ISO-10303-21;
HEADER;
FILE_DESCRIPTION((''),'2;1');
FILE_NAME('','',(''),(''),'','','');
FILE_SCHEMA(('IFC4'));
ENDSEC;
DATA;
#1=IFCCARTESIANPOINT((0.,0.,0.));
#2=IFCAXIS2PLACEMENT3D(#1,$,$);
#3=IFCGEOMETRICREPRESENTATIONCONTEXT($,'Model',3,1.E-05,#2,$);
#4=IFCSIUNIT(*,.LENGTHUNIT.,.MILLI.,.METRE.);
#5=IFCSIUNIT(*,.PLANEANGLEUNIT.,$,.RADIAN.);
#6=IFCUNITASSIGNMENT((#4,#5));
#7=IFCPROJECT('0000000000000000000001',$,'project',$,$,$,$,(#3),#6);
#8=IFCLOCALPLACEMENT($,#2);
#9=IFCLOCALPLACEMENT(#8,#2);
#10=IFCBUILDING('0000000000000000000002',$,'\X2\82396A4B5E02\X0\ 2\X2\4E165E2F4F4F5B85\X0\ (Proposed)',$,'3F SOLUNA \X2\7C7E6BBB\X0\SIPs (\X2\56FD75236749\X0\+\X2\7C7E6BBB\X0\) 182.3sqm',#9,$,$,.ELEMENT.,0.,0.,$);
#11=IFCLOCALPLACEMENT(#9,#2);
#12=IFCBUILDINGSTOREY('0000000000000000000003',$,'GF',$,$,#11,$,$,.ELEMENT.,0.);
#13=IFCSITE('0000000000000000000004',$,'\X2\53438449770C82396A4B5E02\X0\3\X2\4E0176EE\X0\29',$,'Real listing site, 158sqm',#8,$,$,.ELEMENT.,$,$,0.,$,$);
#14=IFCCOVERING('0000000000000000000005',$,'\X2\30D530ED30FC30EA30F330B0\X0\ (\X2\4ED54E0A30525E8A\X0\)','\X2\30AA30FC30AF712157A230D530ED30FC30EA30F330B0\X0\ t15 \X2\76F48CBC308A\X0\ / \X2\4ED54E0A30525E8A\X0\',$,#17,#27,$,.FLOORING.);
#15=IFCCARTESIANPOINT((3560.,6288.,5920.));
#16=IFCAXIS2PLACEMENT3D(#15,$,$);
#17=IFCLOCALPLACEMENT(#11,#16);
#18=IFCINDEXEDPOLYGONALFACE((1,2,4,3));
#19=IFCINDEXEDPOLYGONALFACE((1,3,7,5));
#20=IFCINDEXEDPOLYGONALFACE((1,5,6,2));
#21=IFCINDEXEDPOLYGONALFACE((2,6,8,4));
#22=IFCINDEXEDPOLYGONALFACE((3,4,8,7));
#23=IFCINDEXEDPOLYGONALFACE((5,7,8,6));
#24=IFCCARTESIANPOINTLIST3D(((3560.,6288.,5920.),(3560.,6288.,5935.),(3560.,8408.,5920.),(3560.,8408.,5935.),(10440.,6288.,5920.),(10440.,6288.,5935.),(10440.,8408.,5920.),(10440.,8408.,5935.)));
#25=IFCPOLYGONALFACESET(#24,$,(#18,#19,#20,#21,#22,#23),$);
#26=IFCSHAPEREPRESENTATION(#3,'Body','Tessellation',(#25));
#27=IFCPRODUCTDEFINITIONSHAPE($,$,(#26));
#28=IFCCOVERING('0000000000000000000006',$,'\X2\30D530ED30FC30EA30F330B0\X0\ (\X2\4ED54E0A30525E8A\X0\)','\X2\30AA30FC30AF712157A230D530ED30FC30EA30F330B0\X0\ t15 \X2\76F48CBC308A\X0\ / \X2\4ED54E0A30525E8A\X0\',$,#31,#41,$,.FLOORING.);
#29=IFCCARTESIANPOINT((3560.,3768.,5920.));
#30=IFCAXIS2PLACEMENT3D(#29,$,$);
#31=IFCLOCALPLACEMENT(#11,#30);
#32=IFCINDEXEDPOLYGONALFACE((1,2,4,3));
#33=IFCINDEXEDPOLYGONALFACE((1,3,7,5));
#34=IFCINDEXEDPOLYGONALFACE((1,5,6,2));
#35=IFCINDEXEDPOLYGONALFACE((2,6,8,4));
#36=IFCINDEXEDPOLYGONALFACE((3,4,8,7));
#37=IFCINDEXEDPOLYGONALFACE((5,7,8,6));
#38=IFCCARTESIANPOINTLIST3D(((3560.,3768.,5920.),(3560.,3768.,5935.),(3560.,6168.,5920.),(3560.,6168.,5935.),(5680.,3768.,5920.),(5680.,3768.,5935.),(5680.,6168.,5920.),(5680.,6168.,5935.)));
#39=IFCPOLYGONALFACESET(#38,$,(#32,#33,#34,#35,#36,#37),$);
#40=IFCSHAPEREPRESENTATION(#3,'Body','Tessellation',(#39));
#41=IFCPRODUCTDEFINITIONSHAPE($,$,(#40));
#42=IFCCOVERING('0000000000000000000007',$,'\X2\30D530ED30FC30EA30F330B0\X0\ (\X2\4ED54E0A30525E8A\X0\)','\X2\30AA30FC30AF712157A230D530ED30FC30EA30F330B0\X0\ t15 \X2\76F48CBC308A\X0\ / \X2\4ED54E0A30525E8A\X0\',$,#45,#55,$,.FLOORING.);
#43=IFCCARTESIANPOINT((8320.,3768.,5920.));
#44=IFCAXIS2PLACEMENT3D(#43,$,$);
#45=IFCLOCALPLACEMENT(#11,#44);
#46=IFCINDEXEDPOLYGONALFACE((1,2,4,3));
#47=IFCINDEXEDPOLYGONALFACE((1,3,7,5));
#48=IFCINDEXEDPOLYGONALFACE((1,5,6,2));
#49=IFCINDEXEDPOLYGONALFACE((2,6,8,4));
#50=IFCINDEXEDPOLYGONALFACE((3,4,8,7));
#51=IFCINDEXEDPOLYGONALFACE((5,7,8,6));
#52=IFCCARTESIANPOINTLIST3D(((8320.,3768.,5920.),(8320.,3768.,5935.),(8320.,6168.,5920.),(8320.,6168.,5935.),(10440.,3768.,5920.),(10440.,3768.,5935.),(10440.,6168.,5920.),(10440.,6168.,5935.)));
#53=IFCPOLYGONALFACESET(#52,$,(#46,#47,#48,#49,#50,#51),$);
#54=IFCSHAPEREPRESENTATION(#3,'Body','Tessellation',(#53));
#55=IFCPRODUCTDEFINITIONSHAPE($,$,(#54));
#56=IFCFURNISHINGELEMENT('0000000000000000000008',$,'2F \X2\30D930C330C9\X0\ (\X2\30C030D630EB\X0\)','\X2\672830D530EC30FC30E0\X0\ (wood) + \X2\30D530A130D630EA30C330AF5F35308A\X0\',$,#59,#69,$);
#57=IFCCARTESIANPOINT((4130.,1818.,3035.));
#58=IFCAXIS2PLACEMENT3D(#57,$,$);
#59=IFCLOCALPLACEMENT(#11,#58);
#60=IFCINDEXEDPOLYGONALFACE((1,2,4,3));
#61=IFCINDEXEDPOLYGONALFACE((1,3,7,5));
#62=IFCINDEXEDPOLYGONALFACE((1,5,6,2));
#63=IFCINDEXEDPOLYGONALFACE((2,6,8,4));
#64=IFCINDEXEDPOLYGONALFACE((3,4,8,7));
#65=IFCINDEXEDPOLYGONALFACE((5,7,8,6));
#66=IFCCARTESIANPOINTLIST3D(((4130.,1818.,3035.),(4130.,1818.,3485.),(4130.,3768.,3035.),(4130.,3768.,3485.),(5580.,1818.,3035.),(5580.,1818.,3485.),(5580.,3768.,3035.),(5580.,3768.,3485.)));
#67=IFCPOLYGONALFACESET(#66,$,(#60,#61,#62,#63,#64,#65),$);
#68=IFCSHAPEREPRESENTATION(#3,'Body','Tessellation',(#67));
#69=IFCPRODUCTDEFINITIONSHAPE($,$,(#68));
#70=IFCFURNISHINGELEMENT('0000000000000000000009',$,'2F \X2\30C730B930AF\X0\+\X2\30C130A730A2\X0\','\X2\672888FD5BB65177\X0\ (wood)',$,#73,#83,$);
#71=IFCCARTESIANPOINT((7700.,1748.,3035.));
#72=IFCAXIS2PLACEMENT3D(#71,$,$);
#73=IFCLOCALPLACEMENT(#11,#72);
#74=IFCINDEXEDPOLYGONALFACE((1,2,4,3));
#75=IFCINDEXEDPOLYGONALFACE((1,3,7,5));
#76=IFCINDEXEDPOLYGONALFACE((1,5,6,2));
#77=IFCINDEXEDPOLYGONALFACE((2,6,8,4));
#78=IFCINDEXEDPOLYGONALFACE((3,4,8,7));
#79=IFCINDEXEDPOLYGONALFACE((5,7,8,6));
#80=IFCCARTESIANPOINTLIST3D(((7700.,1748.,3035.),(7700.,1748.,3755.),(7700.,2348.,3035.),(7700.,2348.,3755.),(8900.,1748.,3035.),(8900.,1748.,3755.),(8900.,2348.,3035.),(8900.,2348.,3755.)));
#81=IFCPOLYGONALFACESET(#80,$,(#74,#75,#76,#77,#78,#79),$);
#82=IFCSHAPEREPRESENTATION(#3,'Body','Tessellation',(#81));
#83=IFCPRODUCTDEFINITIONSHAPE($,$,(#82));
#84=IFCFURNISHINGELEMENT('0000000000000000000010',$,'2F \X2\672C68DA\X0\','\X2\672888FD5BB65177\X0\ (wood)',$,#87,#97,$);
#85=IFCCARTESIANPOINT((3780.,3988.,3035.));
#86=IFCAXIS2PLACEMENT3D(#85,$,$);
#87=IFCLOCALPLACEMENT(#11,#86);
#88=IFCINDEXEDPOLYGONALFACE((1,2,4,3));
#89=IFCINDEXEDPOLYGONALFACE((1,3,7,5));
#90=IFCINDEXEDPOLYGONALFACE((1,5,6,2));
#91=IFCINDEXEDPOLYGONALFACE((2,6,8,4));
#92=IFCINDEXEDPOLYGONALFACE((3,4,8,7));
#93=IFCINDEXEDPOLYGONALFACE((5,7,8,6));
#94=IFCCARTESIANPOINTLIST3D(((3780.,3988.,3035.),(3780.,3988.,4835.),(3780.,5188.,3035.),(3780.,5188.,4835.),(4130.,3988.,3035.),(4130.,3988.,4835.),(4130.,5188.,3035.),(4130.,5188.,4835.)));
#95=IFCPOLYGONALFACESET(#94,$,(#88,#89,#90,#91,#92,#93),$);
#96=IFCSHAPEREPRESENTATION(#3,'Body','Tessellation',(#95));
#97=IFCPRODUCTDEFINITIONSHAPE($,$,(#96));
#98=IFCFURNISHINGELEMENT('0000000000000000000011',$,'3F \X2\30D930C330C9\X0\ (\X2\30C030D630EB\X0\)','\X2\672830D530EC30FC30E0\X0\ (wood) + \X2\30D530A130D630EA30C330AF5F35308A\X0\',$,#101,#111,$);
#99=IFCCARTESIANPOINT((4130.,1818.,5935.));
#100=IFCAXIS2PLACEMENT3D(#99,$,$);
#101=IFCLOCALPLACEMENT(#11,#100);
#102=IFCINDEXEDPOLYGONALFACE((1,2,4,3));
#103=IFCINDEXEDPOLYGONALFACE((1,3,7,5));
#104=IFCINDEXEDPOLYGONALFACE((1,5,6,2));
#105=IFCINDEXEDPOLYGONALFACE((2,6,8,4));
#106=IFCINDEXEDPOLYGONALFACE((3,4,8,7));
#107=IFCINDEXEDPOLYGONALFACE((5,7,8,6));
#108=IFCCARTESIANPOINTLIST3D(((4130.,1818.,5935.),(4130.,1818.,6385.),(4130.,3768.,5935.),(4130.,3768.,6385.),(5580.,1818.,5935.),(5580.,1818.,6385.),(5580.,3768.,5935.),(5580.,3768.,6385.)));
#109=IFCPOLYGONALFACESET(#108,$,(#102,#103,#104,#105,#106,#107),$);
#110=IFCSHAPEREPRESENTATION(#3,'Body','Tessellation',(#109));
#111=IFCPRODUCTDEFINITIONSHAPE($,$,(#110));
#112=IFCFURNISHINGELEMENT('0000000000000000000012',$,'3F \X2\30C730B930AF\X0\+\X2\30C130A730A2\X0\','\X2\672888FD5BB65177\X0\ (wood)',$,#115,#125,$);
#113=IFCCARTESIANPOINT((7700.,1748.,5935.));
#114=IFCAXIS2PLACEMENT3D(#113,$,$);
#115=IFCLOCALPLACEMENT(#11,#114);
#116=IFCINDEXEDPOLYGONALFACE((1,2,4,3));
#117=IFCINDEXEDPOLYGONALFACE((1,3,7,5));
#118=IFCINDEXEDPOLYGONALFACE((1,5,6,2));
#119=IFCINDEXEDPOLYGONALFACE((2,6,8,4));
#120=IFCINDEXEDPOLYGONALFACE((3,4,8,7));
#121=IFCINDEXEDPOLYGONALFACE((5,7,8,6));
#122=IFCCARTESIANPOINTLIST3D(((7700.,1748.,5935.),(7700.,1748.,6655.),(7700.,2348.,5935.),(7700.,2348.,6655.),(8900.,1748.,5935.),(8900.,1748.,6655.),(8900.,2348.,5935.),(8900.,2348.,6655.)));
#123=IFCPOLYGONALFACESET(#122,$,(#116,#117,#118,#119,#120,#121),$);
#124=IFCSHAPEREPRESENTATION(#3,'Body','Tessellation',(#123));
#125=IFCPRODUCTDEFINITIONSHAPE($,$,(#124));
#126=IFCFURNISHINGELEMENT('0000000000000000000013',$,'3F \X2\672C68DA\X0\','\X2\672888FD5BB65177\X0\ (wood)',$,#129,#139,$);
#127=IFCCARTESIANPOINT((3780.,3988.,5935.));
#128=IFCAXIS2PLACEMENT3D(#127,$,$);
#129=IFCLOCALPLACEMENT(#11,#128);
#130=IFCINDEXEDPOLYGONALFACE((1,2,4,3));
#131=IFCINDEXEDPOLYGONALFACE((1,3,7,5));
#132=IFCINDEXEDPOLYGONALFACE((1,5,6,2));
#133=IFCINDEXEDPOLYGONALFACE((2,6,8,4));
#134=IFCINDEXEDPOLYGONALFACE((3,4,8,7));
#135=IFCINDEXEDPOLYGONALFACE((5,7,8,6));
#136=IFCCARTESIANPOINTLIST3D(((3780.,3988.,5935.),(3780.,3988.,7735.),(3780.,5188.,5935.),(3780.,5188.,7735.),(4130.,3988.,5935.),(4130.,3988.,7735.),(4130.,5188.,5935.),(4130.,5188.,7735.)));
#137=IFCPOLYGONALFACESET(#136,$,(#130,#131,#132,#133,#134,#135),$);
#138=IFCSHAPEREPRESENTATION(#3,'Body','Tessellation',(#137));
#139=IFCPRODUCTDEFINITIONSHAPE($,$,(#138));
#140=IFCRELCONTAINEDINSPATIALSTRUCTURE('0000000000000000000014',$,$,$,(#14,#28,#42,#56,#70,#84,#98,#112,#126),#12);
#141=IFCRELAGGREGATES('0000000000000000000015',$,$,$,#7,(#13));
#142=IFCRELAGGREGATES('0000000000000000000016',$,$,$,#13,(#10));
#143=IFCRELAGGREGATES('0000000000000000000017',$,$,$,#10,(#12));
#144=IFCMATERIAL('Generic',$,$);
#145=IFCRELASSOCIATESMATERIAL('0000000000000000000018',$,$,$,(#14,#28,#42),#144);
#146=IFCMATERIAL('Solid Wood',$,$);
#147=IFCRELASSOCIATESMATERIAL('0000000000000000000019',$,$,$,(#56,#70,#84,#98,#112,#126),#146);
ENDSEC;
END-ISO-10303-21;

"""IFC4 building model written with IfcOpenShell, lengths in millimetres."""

from ifc_helpers import new_model, si_unit, frame, frame_2d, origin, place, context, project, spatial, rectangle, extrude, material, element, save


model = new_model("IFC4")

# Units and contexts
model_context = context("Model", 3, precision=1e-05, world=origin())
ifc_project = project(units=[si_unit("LENGTHUNIT", "METRE", prefix="MILLI"), si_unit("PLANEANGLEUNIT", "RADIAN")], contexts=[model_context])

# Site, building, storey
site_placement = place(None, origin())
site = spatial("IfcSite", under=ifc_project, at=site_placement, Name="千葉県船橋市3丁目29", ObjectType="Real listing site, 158sqm", CompositionType="ELEMENT", RefElevation=0.0)
building_placement = place(site_placement, origin())
building = spatial("IfcBuilding", under=site, at=building_placement, Name="船橋市 2世帯住宅 (Proposed)", ObjectType="3F SOLUNA 籾殻SIPs (国産杉+籾殻) 182.3sqm", CompositionType="ELEMENT", ElevationOfRefHeight=0.0, ElevationOfTerrain=0.0)
storey_placement = place(building_placement, origin())
storey = spatial("IfcBuildingStorey", under=building, at=storey_placement, Name="GF", CompositionType="ELEMENT", Elevation=0.0)

# Shared definitions
ifc_material_1 = material(Name="Solid Wood")

# Shared definitions
ifc_material_2 = material(Name="Generic")

# Coverings
covering_1_placement = place(storey_placement, frame((3560.0, 6288.0, 5920.0)))
element("IfcCovering", 1, at=covering_1_placement, inside=storey, material=ifc_material_2, Name="フローリング (仕上げ床)", Description="オーク無垢フローリング t15 直貼り / 仕上げ床", PredefinedType="FLOORING", context=model_context, shape_type="SweptSolid", body=[
    extrude(rectangle(XDim=6880.0, YDim=2120.0, at=frame_2d((3440.0, 1060.0))), frame((3560.0, 6288.0, 5920.0)), (0.0, 0.0, 1.0), 15.0),
])
covering_2_placement = place(storey_placement, frame((3560.0, 3768.0, 5920.0)))
element("IfcCovering", 2, at=covering_2_placement, inside=storey, material=ifc_material_2, Name="フローリング (仕上げ床)", Description="オーク無垢フローリング t15 直貼り / 仕上げ床", PredefinedType="FLOORING", context=model_context, shape_type="SweptSolid", body=[
    extrude(rectangle(XDim=2120.0, YDim=2400.0, at=frame_2d((1060.0, 1200.0))), frame((3560.0, 3768.0, 5920.0)), (0.0, 0.0, 1.0), 15.0),
])
covering_3_placement = place(storey_placement, frame((8320.0, 3768.0, 5920.0)))
element("IfcCovering", 3, at=covering_3_placement, inside=storey, material=ifc_material_2, Name="フローリング (仕上げ床)", Description="オーク無垢フローリング t15 直貼り / 仕上げ床", PredefinedType="FLOORING", context=model_context, shape_type="SweptSolid", body=[
    extrude(rectangle(XDim=2120.0, YDim=2400.0, at=frame_2d((1060.0, 1200.0))), frame((8320.0, 3768.0, 5920.0)), (0.0, 0.0, 1.0), 15.0),
])

# Furnishing elements
furnishing_1_placement = place(storey_placement, frame((4130.0, 1818.0, 3035.0)))
element("IfcFurnishingElement", 4, at=furnishing_1_placement, inside=storey, material=ifc_material_1, Name="2F ベッド (ダブル)", Description="木フレーム (wood) + ファブリック張り", context=model_context, shape_type="SweptSolid", body=[
    extrude(rectangle(XDim=1450.0, YDim=1950.0, at=frame_2d((725.0, 975.0))), frame((4130.0, 1818.0, 3035.0)), (0.0, 0.0, 1.0), 450.0),
])
furnishing_2_placement = place(storey_placement, frame((7700.0, 1748.0, 3035.0)))
element("IfcFurnishingElement", 5, at=furnishing_2_placement, inside=storey, material=ifc_material_1, Name="2F デスク+チェア", Description="木製家具 (wood)", context=model_context, shape_type="SweptSolid", body=[
    extrude(rectangle(XDim=1200.0, YDim=600.0, at=frame_2d((600.0, 300.0))), frame((7700.0, 1748.0, 3035.0)), (0.0, 0.0, 1.0), 720.0),
])
furnishing_3_placement = place(storey_placement, frame((3780.0, 3988.0, 3035.0)))
element("IfcFurnishingElement", 6, at=furnishing_3_placement, inside=storey, material=ifc_material_1, Name="2F 本棚", Description="木製家具 (wood)", context=model_context, shape_type="SweptSolid", body=[
    extrude(rectangle(XDim=350.0, YDim=1200.0, at=frame_2d((175.0, 600.0))), frame((3780.0, 3988.0, 3035.0)), (0.0, 0.0, 1.0), 1800.0),
])
furnishing_4_placement = place(storey_placement, frame((4130.0, 1818.0, 5935.0)))
element("IfcFurnishingElement", 7, at=furnishing_4_placement, inside=storey, material=ifc_material_1, Name="3F ベッド (ダブル)", Description="木フレーム (wood) + ファブリック張り", context=model_context, shape_type="SweptSolid", body=[
    extrude(rectangle(XDim=1450.0, YDim=1950.0, at=frame_2d((725.0, 975.0))), frame((4130.0, 1818.0, 5935.0)), (0.0, 0.0, 1.0), 450.0),
])
furnishing_5_placement = place(storey_placement, frame((7700.0, 1748.0, 5935.0)))
element("IfcFurnishingElement", 8, at=furnishing_5_placement, inside=storey, material=ifc_material_1, Name="3F デスク+チェア", Description="木製家具 (wood)", context=model_context, shape_type="SweptSolid", body=[
    extrude(rectangle(XDim=1200.0, YDim=600.0, at=frame_2d((600.0, 300.0))), frame((7700.0, 1748.0, 5935.0)), (0.0, 0.0, 1.0), 720.0),
])
furnishing_6_placement = place(storey_placement, frame((3780.0, 3988.0, 5935.0)))
element("IfcFurnishingElement", 9, at=furnishing_6_placement, inside=storey, material=ifc_material_1, Name="3F 本棚", Description="木製家具 (wood)", context=model_context, shape_type="SweptSolid", body=[
    extrude(rectangle(XDim=350.0, YDim=1200.0, at=frame_2d((175.0, 600.0))), frame((3780.0, 3988.0, 5935.0)), (0.0, 0.0, 1.0), 1800.0),
])

save(model, "model.ifc")
